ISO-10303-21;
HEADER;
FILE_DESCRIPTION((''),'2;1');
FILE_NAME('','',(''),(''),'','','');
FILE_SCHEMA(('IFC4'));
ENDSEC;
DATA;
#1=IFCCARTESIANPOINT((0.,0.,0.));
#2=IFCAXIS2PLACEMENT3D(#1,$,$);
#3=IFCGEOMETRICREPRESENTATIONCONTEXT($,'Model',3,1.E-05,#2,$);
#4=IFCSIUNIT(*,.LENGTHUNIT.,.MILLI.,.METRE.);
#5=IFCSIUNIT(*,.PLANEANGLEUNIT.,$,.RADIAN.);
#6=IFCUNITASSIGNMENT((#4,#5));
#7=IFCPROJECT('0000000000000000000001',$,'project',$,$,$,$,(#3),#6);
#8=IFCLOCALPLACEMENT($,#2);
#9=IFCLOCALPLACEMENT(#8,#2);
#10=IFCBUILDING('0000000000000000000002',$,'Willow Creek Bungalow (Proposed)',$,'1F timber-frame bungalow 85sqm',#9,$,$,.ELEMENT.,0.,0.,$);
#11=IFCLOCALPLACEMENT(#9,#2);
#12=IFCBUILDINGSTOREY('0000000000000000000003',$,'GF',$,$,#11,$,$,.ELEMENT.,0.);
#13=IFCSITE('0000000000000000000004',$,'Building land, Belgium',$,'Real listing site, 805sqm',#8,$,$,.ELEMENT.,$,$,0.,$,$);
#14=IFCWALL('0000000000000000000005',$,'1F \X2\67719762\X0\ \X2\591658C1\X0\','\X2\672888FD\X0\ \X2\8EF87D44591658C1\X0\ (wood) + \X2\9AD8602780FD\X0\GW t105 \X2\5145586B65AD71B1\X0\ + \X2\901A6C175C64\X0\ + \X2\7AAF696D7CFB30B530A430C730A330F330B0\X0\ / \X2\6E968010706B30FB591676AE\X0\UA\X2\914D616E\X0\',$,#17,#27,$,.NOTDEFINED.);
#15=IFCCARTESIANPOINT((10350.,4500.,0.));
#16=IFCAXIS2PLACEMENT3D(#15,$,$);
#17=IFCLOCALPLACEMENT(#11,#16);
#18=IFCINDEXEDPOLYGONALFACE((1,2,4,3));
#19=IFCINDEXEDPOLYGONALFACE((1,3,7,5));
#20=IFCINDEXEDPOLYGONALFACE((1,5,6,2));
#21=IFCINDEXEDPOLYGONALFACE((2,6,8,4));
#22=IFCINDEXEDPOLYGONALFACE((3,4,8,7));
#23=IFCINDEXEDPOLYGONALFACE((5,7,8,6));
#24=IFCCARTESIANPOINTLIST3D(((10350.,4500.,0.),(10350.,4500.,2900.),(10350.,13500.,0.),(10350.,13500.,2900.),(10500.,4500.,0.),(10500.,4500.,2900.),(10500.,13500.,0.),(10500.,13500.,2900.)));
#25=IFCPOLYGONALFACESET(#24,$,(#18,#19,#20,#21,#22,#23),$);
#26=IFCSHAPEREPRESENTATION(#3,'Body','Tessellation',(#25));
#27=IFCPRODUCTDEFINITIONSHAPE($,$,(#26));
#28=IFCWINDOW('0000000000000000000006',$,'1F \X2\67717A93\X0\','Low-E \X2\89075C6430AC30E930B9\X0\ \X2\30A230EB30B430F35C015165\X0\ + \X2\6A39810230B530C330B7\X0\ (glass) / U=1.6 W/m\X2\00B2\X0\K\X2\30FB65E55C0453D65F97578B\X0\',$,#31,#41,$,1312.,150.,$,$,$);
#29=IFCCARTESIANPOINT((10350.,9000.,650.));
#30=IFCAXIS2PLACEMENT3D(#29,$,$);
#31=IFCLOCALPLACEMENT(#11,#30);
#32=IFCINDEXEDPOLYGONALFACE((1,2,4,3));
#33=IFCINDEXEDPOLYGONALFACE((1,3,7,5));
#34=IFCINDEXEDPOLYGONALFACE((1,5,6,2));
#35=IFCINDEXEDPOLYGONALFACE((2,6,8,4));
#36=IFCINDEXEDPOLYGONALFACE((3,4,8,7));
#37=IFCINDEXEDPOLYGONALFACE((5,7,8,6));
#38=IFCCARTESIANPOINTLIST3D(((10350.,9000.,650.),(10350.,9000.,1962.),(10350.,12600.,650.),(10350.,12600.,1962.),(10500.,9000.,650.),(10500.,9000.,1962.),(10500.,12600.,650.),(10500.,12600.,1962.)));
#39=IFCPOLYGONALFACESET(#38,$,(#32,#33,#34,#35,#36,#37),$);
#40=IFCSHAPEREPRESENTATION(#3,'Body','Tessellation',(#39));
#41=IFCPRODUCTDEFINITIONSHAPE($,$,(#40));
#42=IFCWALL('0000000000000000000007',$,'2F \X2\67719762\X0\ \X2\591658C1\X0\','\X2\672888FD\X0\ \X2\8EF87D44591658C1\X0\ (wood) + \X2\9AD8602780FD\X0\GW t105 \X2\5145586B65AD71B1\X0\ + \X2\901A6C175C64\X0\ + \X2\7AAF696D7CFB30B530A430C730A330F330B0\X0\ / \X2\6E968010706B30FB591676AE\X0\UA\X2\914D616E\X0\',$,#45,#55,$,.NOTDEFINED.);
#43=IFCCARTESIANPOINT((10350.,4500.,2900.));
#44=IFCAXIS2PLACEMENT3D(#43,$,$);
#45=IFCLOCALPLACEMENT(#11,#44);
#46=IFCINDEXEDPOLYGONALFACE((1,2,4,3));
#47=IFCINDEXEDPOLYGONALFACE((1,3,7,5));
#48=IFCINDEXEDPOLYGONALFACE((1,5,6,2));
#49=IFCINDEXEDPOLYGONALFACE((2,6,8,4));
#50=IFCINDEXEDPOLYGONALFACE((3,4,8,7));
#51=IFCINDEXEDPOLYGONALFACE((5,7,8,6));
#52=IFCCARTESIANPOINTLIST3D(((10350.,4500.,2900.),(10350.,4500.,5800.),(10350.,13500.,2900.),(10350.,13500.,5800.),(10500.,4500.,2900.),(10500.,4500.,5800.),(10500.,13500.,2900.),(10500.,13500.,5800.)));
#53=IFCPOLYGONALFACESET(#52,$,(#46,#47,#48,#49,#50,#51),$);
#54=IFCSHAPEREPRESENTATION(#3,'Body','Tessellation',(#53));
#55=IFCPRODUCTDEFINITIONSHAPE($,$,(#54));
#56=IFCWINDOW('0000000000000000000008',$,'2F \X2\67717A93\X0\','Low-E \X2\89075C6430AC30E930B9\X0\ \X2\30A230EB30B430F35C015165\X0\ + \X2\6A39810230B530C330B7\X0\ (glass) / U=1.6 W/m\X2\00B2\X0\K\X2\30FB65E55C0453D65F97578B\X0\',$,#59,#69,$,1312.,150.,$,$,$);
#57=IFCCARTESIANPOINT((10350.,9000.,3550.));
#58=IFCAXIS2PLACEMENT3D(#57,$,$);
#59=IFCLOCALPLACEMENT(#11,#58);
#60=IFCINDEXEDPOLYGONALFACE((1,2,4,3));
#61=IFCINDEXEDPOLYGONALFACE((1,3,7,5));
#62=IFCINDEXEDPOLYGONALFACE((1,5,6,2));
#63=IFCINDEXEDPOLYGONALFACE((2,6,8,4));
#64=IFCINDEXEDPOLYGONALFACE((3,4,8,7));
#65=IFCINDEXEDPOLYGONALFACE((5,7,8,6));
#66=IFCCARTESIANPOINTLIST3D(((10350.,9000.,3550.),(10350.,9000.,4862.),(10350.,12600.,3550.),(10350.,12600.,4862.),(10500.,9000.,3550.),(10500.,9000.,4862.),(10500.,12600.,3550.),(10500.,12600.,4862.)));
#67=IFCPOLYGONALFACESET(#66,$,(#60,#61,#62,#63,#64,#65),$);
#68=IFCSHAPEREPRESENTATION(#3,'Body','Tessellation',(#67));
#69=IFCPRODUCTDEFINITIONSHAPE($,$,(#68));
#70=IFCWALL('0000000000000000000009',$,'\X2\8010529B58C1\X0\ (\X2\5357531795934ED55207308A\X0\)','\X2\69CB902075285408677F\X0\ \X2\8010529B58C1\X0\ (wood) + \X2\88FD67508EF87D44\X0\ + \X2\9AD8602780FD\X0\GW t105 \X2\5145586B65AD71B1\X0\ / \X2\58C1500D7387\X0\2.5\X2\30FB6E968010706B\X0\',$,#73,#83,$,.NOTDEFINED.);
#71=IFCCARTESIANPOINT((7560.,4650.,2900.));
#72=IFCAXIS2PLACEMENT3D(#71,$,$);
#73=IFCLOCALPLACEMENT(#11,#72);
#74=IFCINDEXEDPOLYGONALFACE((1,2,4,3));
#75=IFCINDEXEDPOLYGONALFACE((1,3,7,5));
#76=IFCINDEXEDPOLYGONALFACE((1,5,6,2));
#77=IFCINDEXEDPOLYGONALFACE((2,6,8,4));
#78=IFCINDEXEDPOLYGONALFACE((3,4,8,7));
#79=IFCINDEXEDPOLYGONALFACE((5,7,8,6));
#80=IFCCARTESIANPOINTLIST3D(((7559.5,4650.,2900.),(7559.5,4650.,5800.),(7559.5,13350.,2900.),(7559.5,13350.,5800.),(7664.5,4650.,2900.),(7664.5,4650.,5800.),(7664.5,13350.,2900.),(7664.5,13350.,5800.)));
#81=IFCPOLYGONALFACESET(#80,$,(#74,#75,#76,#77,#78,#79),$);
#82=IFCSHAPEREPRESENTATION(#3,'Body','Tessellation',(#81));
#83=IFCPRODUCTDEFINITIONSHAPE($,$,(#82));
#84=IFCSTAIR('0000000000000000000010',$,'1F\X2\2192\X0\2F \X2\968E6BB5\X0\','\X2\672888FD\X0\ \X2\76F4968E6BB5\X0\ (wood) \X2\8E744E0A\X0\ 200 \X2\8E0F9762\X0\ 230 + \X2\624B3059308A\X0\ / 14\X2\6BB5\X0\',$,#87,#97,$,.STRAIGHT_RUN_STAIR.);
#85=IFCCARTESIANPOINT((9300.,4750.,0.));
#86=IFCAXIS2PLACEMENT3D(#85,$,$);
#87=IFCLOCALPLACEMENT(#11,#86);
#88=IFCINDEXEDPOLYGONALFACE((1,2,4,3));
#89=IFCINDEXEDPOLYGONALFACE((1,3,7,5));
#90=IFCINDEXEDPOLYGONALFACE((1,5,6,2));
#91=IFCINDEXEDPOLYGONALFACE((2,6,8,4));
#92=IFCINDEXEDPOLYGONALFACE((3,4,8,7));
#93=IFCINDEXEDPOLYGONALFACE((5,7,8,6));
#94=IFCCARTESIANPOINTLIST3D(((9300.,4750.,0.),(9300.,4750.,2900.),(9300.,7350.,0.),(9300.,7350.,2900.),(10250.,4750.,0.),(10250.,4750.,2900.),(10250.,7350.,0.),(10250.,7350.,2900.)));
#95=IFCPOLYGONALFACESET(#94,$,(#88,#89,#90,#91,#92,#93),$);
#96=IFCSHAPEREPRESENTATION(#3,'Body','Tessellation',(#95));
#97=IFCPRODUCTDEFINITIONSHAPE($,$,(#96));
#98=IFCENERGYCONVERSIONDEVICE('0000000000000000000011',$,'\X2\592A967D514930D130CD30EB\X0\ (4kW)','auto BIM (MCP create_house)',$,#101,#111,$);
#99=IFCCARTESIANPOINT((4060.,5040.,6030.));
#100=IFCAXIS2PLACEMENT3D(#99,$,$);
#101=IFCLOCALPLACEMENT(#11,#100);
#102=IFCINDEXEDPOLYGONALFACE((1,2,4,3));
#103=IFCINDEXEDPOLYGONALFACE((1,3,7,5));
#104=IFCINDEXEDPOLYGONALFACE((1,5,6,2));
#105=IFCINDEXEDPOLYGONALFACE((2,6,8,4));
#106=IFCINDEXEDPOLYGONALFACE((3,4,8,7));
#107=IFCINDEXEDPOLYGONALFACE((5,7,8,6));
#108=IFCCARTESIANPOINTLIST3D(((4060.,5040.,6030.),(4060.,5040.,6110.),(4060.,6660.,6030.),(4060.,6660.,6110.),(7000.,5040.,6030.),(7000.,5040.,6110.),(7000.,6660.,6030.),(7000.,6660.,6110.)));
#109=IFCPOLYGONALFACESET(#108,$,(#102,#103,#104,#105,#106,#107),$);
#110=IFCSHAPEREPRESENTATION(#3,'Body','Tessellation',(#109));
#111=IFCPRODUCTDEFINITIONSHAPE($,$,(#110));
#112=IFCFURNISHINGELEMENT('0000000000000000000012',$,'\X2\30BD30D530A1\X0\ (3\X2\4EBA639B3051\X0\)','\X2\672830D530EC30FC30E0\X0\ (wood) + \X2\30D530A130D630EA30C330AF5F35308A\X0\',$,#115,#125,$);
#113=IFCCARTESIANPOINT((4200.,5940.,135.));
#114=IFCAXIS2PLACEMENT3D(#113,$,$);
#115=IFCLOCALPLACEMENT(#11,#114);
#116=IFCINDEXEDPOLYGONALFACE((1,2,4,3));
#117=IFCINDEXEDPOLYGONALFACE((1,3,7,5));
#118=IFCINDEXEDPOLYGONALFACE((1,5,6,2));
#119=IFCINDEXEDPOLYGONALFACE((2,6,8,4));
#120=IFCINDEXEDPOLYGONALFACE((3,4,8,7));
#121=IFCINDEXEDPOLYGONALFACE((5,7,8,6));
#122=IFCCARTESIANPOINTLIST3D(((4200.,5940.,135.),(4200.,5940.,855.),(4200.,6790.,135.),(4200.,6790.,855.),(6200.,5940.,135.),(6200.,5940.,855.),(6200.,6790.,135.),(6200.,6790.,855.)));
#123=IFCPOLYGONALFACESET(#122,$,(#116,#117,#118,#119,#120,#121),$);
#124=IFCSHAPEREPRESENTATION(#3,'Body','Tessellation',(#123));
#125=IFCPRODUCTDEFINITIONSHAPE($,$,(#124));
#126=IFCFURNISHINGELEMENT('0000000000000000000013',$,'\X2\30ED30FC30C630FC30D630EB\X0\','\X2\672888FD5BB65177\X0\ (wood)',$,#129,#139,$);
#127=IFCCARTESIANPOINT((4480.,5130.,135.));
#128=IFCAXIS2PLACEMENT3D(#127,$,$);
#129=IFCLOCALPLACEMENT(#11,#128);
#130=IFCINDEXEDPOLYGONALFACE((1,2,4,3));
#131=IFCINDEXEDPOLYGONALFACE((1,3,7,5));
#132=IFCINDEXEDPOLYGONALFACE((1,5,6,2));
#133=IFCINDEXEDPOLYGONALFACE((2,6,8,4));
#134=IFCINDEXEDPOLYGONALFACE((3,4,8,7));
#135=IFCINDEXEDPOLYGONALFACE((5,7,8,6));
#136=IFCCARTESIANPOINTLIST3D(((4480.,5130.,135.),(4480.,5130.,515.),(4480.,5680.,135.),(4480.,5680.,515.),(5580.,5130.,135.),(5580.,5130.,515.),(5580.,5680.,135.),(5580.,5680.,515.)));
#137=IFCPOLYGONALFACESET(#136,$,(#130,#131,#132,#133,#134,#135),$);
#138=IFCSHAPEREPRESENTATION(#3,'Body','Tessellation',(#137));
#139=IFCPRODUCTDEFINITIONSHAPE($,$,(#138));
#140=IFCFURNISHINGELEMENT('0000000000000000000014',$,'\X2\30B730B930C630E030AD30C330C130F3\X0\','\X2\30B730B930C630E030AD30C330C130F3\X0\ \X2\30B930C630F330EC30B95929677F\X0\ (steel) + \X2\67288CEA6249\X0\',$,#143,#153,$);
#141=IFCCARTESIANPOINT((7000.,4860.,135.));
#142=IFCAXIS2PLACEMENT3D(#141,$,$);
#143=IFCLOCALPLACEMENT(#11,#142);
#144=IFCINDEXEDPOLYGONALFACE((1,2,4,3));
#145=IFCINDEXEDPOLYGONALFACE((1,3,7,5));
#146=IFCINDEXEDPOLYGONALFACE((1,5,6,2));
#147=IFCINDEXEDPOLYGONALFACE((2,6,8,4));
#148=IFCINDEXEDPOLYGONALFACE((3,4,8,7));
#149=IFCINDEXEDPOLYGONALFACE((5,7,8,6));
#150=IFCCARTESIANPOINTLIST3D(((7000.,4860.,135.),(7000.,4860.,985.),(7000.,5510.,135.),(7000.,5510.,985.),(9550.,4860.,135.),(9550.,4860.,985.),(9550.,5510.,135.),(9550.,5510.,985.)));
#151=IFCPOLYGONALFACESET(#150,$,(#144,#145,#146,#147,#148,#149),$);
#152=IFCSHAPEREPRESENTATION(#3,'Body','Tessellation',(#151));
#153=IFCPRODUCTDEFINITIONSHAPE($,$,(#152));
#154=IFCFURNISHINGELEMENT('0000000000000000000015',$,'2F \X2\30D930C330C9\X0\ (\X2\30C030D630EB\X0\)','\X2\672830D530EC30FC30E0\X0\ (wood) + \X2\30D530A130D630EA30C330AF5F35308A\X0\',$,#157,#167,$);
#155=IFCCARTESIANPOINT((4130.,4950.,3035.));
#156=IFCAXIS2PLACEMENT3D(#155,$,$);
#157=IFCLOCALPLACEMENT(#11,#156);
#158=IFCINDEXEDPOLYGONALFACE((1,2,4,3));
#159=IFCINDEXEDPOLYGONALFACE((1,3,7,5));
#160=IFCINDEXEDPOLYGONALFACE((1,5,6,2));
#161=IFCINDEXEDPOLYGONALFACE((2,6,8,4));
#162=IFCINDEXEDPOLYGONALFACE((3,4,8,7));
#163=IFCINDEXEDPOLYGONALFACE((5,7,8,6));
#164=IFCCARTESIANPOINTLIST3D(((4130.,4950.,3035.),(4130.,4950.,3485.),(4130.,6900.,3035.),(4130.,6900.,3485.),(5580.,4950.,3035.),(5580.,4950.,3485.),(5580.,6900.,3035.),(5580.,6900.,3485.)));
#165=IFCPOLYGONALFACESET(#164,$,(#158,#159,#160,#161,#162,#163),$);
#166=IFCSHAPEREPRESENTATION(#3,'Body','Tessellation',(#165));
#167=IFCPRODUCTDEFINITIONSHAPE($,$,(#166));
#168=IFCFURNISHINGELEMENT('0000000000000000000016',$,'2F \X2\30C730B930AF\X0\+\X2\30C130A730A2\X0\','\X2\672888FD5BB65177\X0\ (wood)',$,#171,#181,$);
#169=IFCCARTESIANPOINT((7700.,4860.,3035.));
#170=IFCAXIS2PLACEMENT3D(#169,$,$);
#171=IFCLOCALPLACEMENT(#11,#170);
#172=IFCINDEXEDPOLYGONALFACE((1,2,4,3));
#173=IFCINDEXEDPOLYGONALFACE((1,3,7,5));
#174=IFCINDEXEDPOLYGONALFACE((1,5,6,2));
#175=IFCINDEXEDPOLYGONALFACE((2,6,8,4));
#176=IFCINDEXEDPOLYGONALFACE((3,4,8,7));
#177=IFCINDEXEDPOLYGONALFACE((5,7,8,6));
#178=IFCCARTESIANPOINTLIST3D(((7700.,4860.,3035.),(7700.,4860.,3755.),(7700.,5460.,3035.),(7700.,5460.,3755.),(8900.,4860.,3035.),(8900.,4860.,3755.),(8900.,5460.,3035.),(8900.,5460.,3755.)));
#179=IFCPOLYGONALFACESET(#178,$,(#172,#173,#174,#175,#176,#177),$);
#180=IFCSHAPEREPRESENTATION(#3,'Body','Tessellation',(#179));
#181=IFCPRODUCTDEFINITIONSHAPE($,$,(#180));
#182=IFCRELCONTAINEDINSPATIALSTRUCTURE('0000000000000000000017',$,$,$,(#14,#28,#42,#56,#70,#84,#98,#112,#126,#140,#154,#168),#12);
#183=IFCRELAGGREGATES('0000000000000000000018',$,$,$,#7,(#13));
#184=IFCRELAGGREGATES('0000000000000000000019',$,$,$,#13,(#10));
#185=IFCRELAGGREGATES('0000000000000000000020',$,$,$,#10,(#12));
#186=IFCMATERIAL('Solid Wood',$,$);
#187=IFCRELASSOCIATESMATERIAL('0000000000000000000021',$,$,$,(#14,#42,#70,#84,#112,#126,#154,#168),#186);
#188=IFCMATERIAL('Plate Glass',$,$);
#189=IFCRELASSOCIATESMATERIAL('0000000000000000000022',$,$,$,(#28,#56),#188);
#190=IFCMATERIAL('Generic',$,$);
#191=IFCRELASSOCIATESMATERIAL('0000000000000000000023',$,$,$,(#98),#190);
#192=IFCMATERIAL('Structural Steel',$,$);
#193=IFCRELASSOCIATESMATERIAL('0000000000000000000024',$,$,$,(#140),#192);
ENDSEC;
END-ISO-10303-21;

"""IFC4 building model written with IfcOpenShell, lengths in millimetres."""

from ifc_helpers import new_model, si_unit, frame, frame_2d, origin, place, context, project, spatial, rectangle, extrude, material, element, fill, save


model = new_model("IFC4")

# Units and contexts
model_context = context("Model", 3, precision=1e-05, world=origin())
ifc_project = project(units=[si_unit("LENGTHUNIT", "METRE", prefix="MILLI"), si_unit("PLANEANGLEUNIT", "RADIAN")], contexts=[model_context])

# Site, building, storey
site_placement = place(None, origin())
site = spatial("IfcSite", under=ifc_project, at=site_placement, Name="Building land, Belgium", ObjectType="Real listing site, 805sqm", CompositionType="ELEMENT", RefElevation=0.0)
building_placement = place(site_placement, origin())
building = spatial("IfcBuilding", under=site, at=building_placement, Name="Willow Creek Bungalow (Proposed)", ObjectType="1F timber-frame bungalow 85sqm", CompositionType="ELEMENT", ElevationOfRefHeight=0.0, ElevationOfTerrain=0.0)
storey_placement = place(building_placement, origin())
storey = spatial("IfcBuildingStorey", under=building, at=storey_placement, Name="GF", CompositionType="ELEMENT", Elevation=0.0)

# Wall, opening, window
ifc_material_1 = material(Name="Solid Wood")
wall_1_placement = place(storey_placement, frame((10350.0, 4500.0, 0.0)))
wall_1 = element("IfcWall", 1, at=wall_1_placement, inside=storey, material=ifc_material_1, Name="1F 東面 外壁", Description="木製 軸組外壁 (wood) + 高性能GW t105 充填断熱 + 通気層 + 窯業系サイディング / 準耐火・外皮UA配慮", PredefinedType="NOTDEFINED", context=model_context, shape_type="SweptSolid", body=[
    extrude(rectangle(XDim=150.0, YDim=9000.0, at=frame_2d((75.0, 4500.0))), frame((10350.0, 4500.0, 0.0)), (0.0, 0.0, 1.0), 2900.0),
])
opening_1_placement = place(storey_placement, frame((10350.0, 9000.0, 650.0)))
opening_1 = element("IfcOpeningElement", 2, at=opening_1_placement, cuts=wall_1, PredefinedType="NOTDEFINED", context=model_context, shape_type="SweptSolid", body=[
    extrude(rectangle(XDim=150.0, YDim=3600.0, at=frame_2d((75.0, 1800.0))), frame((10350.0, 9000.0, 650.0)), (0.0, 0.0, 1.0), 1312.0),
])
ifc_material_2 = material(Name="Plate Glass")
window_1_placement = place(storey_placement, frame((10350.0, 9000.0, 650.0)))
window_1 = element("IfcWindow", 3, at=window_1_placement, inside=storey, material=ifc_material_2, Name="1F 東窓", Description="Low-E 複層ガラス アルゴン封入 + 樹脂サッシ (glass) / U=1.6 W/m²K・日射取得型", OverallHeight=1312.0, OverallWidth=150.0, context=model_context, shape_type="SweptSolid", body=[
    extrude(rectangle(XDim=150.0, YDim=3600.0, at=frame_2d((75.0, 1800.0))), frame((10350.0, 9000.0, 650.0)), (0.0, 0.0, 1.0), 1312.0),
])
fill(opening_1, window_1)

# Wall, opening, window
wall_2_placement = place(storey_placement, frame((10350.0, 4500.0, 2900.0)))
wall_2 = element("IfcWall", 4, at=wall_2_placement, inside=storey, material=ifc_material_1, Name="2F 東面 外壁", Description="木製 軸組外壁 (wood) + 高性能GW t105 充填断熱 + 通気層 + 窯業系サイディング / 準耐火・外皮UA配慮", PredefinedType="NOTDEFINED", context=model_context, shape_type="SweptSolid", body=[
    extrude(rectangle(XDim=150.0, YDim=9000.0, at=frame_2d((75.0, 4500.0))), frame((10350.0, 4500.0, 2900.0)), (0.0, 0.0, 1.0), 2900.0),
])
opening_2_placement = place(storey_placement, frame((10350.0, 9000.0, 3550.0)))
opening_2 = element("IfcOpeningElement", 5, at=opening_2_placement, cuts=wall_2, PredefinedType="NOTDEFINED", context=model_context, shape_type="SweptSolid", body=[
    extrude(rectangle(XDim=150.0, YDim=3600.0, at=frame_2d((75.0, 1800.0))), frame((10350.0, 9000.0, 3550.0)), (0.0, 0.0, 1.0), 1312.0),
])
window_2_placement = place(storey_placement, frame((10350.0, 9000.0, 3550.0)))
window_2 = element("IfcWindow", 6, at=window_2_placement, inside=storey, material=ifc_material_2, Name="2F 東窓", Description="Low-E 複層ガラス アルゴン封入 + 樹脂サッシ (glass) / U=1.6 W/m²K・日射取得型", OverallHeight=1312.0, OverallWidth=150.0, context=model_context, shape_type="SweptSolid", body=[
    extrude(rectangle(XDim=150.0, YDim=3600.0, at=frame_2d((75.0, 1800.0))), frame((10350.0, 9000.0, 3550.0)), (0.0, 0.0, 1.0), 1312.0),
])
fill(opening_2, window_2)

# Wall
wall_3_placement = place(storey_placement, frame((7560.0, 4650.0, 2900.0)))
element("IfcWall", 7, at=wall_3_placement, inside=storey, material=ifc_material_1, Name="耐力壁 (南北間仕切り)", Description="構造用合板 耐力壁 (wood) + 製材軸組 + 高性能GW t105 充填断熱 / 壁倍率2.5・準耐火", PredefinedType="NOTDEFINED", context=model_context, shape_type="SweptSolid", body=[
    extrude(rectangle(XDim=105.0, YDim=8700.0, at=frame_2d((52.0, 4350.0))), frame((7560.0, 4650.0, 2900.0)), (0.0, 0.0, 1.0), 2900.0),
])

# Stair
stair_placement = place(storey_placement, frame((9300.0, 4750.0, 0.0)))
element("IfcStair", 8, at=stair_placement, inside=storey, material=ifc_material_1, Name="1F→2F 階段", Description="木製 直階段 (wood) 蹴上 200 踏面 230 + 手すり / 14段", PredefinedType="STRAIGHT_RUN_STAIR", context=model_context, shape_type="SweptSolid", body=[
    extrude(rectangle(XDim=950.0, YDim=2600.0, at=frame_2d((475.0, 1300.0))), frame((9300.0, 4750.0, 0.0)), (0.0, 0.0, 1.0), 2900.0),
])

# Energy conversion device
ifc_material_3 = material(Name="Generic")
energy_conversion_device_placement = place(storey_placement, frame((4060.0, 5040.0, 6030.0)))
element("IfcEnergyConversionDevice", 9, at=energy_conversion_device_placement, inside=storey, material=ifc_material_3, Name="太陽光パネル (4kW)", Description="auto BIM (MCP create_house)", context=model_context, shape_type="SweptSolid", body=[
    extrude(rectangle(XDim=2940.0, YDim=1620.0, at=frame_2d((1470.0, 810.0))), frame((4060.0, 5040.0, 6030.0)), (0.0, 0.0, 1.0), 80.0),
])

# Furnishing elements
furnishing_1_placement = place(storey_placement, frame((4200.0, 5940.0, 135.0)))
element("IfcFurnishingElement", 10, at=furnishing_1_placement, inside=storey, material=ifc_material_1, Name="ソファ (3人掛け)", Description="木フレーム (wood) + ファブリック張り", context=model_context, shape_type="SweptSolid", body=[
    extrude(rectangle(XDim=2000.0, YDim=850.0, at=frame_2d((1000.0, 425.0))), frame((4200.0, 5940.0, 135.0)), (0.0, 0.0, 1.0), 720.0),
])
furnishing_2_placement = place(storey_placement, frame((4480.0, 5130.0, 135.0)))
element("IfcFurnishingElement", 11, at=furnishing_2_placement, inside=storey, material=ifc_material_1, Name="ローテーブル", Description="木製家具 (wood)", context=model_context, shape_type="SweptSolid", body=[
    extrude(rectangle(XDim=1100.0, YDim=550.0, at=frame_2d((550.0, 275.0))), frame((4480.0, 5130.0, 135.0)), (0.0, 0.0, 1.0), 380.0),
])
ifc_material_4 = material(Name="Structural Steel")
furnishing_3_placement = place(storey_placement, frame((7000.0, 4860.0, 135.0)))
element("IfcFurnishingElement", 12, at=furnishing_3_placement, inside=storey, material=ifc_material_4, Name="システムキッチン", Description="システムキッチン ステンレス天板 (steel) + 木質扉", context=model_context, shape_type="SweptSolid", body=[
    extrude(rectangle(XDim=2550.0, YDim=650.0, at=frame_2d((1275.0, 325.0))), frame((7000.0, 4860.0, 135.0)), (0.0, 0.0, 1.0), 850.0),
])
furnishing_4_placement = place(storey_placement, frame((4130.0, 4950.0, 3035.0)))
element("IfcFurnishingElement", 13, at=furnishing_4_placement, inside=storey, material=ifc_material_1, Name="2F ベッド (ダブル)", Description="木フレーム (wood) + ファブリック張り", context=model_context, shape_type="SweptSolid", body=[
    extrude(rectangle(XDim=1450.0, YDim=1950.0, at=frame_2d((725.0, 975.0))), frame((4130.0, 4950.0, 3035.0)), (0.0, 0.0, 1.0), 450.0),
])
furnishing_5_placement = place(storey_placement, frame((7700.0, 4860.0, 3035.0)))
element("IfcFurnishingElement", 14, at=furnishing_5_placement, inside=storey, material=ifc_material_1, Name="2F デスク+チェア", Description="木製家具 (wood)", context=model_context, shape_type="SweptSolid", body=[
    extrude(rectangle(XDim=1200.0, YDim=600.0, at=frame_2d((600.0, 300.0))), frame((7700.0, 4860.0, 3035.0)), (0.0, 0.0, 1.0), 720.0),
])

save(model, "model.ifc")
